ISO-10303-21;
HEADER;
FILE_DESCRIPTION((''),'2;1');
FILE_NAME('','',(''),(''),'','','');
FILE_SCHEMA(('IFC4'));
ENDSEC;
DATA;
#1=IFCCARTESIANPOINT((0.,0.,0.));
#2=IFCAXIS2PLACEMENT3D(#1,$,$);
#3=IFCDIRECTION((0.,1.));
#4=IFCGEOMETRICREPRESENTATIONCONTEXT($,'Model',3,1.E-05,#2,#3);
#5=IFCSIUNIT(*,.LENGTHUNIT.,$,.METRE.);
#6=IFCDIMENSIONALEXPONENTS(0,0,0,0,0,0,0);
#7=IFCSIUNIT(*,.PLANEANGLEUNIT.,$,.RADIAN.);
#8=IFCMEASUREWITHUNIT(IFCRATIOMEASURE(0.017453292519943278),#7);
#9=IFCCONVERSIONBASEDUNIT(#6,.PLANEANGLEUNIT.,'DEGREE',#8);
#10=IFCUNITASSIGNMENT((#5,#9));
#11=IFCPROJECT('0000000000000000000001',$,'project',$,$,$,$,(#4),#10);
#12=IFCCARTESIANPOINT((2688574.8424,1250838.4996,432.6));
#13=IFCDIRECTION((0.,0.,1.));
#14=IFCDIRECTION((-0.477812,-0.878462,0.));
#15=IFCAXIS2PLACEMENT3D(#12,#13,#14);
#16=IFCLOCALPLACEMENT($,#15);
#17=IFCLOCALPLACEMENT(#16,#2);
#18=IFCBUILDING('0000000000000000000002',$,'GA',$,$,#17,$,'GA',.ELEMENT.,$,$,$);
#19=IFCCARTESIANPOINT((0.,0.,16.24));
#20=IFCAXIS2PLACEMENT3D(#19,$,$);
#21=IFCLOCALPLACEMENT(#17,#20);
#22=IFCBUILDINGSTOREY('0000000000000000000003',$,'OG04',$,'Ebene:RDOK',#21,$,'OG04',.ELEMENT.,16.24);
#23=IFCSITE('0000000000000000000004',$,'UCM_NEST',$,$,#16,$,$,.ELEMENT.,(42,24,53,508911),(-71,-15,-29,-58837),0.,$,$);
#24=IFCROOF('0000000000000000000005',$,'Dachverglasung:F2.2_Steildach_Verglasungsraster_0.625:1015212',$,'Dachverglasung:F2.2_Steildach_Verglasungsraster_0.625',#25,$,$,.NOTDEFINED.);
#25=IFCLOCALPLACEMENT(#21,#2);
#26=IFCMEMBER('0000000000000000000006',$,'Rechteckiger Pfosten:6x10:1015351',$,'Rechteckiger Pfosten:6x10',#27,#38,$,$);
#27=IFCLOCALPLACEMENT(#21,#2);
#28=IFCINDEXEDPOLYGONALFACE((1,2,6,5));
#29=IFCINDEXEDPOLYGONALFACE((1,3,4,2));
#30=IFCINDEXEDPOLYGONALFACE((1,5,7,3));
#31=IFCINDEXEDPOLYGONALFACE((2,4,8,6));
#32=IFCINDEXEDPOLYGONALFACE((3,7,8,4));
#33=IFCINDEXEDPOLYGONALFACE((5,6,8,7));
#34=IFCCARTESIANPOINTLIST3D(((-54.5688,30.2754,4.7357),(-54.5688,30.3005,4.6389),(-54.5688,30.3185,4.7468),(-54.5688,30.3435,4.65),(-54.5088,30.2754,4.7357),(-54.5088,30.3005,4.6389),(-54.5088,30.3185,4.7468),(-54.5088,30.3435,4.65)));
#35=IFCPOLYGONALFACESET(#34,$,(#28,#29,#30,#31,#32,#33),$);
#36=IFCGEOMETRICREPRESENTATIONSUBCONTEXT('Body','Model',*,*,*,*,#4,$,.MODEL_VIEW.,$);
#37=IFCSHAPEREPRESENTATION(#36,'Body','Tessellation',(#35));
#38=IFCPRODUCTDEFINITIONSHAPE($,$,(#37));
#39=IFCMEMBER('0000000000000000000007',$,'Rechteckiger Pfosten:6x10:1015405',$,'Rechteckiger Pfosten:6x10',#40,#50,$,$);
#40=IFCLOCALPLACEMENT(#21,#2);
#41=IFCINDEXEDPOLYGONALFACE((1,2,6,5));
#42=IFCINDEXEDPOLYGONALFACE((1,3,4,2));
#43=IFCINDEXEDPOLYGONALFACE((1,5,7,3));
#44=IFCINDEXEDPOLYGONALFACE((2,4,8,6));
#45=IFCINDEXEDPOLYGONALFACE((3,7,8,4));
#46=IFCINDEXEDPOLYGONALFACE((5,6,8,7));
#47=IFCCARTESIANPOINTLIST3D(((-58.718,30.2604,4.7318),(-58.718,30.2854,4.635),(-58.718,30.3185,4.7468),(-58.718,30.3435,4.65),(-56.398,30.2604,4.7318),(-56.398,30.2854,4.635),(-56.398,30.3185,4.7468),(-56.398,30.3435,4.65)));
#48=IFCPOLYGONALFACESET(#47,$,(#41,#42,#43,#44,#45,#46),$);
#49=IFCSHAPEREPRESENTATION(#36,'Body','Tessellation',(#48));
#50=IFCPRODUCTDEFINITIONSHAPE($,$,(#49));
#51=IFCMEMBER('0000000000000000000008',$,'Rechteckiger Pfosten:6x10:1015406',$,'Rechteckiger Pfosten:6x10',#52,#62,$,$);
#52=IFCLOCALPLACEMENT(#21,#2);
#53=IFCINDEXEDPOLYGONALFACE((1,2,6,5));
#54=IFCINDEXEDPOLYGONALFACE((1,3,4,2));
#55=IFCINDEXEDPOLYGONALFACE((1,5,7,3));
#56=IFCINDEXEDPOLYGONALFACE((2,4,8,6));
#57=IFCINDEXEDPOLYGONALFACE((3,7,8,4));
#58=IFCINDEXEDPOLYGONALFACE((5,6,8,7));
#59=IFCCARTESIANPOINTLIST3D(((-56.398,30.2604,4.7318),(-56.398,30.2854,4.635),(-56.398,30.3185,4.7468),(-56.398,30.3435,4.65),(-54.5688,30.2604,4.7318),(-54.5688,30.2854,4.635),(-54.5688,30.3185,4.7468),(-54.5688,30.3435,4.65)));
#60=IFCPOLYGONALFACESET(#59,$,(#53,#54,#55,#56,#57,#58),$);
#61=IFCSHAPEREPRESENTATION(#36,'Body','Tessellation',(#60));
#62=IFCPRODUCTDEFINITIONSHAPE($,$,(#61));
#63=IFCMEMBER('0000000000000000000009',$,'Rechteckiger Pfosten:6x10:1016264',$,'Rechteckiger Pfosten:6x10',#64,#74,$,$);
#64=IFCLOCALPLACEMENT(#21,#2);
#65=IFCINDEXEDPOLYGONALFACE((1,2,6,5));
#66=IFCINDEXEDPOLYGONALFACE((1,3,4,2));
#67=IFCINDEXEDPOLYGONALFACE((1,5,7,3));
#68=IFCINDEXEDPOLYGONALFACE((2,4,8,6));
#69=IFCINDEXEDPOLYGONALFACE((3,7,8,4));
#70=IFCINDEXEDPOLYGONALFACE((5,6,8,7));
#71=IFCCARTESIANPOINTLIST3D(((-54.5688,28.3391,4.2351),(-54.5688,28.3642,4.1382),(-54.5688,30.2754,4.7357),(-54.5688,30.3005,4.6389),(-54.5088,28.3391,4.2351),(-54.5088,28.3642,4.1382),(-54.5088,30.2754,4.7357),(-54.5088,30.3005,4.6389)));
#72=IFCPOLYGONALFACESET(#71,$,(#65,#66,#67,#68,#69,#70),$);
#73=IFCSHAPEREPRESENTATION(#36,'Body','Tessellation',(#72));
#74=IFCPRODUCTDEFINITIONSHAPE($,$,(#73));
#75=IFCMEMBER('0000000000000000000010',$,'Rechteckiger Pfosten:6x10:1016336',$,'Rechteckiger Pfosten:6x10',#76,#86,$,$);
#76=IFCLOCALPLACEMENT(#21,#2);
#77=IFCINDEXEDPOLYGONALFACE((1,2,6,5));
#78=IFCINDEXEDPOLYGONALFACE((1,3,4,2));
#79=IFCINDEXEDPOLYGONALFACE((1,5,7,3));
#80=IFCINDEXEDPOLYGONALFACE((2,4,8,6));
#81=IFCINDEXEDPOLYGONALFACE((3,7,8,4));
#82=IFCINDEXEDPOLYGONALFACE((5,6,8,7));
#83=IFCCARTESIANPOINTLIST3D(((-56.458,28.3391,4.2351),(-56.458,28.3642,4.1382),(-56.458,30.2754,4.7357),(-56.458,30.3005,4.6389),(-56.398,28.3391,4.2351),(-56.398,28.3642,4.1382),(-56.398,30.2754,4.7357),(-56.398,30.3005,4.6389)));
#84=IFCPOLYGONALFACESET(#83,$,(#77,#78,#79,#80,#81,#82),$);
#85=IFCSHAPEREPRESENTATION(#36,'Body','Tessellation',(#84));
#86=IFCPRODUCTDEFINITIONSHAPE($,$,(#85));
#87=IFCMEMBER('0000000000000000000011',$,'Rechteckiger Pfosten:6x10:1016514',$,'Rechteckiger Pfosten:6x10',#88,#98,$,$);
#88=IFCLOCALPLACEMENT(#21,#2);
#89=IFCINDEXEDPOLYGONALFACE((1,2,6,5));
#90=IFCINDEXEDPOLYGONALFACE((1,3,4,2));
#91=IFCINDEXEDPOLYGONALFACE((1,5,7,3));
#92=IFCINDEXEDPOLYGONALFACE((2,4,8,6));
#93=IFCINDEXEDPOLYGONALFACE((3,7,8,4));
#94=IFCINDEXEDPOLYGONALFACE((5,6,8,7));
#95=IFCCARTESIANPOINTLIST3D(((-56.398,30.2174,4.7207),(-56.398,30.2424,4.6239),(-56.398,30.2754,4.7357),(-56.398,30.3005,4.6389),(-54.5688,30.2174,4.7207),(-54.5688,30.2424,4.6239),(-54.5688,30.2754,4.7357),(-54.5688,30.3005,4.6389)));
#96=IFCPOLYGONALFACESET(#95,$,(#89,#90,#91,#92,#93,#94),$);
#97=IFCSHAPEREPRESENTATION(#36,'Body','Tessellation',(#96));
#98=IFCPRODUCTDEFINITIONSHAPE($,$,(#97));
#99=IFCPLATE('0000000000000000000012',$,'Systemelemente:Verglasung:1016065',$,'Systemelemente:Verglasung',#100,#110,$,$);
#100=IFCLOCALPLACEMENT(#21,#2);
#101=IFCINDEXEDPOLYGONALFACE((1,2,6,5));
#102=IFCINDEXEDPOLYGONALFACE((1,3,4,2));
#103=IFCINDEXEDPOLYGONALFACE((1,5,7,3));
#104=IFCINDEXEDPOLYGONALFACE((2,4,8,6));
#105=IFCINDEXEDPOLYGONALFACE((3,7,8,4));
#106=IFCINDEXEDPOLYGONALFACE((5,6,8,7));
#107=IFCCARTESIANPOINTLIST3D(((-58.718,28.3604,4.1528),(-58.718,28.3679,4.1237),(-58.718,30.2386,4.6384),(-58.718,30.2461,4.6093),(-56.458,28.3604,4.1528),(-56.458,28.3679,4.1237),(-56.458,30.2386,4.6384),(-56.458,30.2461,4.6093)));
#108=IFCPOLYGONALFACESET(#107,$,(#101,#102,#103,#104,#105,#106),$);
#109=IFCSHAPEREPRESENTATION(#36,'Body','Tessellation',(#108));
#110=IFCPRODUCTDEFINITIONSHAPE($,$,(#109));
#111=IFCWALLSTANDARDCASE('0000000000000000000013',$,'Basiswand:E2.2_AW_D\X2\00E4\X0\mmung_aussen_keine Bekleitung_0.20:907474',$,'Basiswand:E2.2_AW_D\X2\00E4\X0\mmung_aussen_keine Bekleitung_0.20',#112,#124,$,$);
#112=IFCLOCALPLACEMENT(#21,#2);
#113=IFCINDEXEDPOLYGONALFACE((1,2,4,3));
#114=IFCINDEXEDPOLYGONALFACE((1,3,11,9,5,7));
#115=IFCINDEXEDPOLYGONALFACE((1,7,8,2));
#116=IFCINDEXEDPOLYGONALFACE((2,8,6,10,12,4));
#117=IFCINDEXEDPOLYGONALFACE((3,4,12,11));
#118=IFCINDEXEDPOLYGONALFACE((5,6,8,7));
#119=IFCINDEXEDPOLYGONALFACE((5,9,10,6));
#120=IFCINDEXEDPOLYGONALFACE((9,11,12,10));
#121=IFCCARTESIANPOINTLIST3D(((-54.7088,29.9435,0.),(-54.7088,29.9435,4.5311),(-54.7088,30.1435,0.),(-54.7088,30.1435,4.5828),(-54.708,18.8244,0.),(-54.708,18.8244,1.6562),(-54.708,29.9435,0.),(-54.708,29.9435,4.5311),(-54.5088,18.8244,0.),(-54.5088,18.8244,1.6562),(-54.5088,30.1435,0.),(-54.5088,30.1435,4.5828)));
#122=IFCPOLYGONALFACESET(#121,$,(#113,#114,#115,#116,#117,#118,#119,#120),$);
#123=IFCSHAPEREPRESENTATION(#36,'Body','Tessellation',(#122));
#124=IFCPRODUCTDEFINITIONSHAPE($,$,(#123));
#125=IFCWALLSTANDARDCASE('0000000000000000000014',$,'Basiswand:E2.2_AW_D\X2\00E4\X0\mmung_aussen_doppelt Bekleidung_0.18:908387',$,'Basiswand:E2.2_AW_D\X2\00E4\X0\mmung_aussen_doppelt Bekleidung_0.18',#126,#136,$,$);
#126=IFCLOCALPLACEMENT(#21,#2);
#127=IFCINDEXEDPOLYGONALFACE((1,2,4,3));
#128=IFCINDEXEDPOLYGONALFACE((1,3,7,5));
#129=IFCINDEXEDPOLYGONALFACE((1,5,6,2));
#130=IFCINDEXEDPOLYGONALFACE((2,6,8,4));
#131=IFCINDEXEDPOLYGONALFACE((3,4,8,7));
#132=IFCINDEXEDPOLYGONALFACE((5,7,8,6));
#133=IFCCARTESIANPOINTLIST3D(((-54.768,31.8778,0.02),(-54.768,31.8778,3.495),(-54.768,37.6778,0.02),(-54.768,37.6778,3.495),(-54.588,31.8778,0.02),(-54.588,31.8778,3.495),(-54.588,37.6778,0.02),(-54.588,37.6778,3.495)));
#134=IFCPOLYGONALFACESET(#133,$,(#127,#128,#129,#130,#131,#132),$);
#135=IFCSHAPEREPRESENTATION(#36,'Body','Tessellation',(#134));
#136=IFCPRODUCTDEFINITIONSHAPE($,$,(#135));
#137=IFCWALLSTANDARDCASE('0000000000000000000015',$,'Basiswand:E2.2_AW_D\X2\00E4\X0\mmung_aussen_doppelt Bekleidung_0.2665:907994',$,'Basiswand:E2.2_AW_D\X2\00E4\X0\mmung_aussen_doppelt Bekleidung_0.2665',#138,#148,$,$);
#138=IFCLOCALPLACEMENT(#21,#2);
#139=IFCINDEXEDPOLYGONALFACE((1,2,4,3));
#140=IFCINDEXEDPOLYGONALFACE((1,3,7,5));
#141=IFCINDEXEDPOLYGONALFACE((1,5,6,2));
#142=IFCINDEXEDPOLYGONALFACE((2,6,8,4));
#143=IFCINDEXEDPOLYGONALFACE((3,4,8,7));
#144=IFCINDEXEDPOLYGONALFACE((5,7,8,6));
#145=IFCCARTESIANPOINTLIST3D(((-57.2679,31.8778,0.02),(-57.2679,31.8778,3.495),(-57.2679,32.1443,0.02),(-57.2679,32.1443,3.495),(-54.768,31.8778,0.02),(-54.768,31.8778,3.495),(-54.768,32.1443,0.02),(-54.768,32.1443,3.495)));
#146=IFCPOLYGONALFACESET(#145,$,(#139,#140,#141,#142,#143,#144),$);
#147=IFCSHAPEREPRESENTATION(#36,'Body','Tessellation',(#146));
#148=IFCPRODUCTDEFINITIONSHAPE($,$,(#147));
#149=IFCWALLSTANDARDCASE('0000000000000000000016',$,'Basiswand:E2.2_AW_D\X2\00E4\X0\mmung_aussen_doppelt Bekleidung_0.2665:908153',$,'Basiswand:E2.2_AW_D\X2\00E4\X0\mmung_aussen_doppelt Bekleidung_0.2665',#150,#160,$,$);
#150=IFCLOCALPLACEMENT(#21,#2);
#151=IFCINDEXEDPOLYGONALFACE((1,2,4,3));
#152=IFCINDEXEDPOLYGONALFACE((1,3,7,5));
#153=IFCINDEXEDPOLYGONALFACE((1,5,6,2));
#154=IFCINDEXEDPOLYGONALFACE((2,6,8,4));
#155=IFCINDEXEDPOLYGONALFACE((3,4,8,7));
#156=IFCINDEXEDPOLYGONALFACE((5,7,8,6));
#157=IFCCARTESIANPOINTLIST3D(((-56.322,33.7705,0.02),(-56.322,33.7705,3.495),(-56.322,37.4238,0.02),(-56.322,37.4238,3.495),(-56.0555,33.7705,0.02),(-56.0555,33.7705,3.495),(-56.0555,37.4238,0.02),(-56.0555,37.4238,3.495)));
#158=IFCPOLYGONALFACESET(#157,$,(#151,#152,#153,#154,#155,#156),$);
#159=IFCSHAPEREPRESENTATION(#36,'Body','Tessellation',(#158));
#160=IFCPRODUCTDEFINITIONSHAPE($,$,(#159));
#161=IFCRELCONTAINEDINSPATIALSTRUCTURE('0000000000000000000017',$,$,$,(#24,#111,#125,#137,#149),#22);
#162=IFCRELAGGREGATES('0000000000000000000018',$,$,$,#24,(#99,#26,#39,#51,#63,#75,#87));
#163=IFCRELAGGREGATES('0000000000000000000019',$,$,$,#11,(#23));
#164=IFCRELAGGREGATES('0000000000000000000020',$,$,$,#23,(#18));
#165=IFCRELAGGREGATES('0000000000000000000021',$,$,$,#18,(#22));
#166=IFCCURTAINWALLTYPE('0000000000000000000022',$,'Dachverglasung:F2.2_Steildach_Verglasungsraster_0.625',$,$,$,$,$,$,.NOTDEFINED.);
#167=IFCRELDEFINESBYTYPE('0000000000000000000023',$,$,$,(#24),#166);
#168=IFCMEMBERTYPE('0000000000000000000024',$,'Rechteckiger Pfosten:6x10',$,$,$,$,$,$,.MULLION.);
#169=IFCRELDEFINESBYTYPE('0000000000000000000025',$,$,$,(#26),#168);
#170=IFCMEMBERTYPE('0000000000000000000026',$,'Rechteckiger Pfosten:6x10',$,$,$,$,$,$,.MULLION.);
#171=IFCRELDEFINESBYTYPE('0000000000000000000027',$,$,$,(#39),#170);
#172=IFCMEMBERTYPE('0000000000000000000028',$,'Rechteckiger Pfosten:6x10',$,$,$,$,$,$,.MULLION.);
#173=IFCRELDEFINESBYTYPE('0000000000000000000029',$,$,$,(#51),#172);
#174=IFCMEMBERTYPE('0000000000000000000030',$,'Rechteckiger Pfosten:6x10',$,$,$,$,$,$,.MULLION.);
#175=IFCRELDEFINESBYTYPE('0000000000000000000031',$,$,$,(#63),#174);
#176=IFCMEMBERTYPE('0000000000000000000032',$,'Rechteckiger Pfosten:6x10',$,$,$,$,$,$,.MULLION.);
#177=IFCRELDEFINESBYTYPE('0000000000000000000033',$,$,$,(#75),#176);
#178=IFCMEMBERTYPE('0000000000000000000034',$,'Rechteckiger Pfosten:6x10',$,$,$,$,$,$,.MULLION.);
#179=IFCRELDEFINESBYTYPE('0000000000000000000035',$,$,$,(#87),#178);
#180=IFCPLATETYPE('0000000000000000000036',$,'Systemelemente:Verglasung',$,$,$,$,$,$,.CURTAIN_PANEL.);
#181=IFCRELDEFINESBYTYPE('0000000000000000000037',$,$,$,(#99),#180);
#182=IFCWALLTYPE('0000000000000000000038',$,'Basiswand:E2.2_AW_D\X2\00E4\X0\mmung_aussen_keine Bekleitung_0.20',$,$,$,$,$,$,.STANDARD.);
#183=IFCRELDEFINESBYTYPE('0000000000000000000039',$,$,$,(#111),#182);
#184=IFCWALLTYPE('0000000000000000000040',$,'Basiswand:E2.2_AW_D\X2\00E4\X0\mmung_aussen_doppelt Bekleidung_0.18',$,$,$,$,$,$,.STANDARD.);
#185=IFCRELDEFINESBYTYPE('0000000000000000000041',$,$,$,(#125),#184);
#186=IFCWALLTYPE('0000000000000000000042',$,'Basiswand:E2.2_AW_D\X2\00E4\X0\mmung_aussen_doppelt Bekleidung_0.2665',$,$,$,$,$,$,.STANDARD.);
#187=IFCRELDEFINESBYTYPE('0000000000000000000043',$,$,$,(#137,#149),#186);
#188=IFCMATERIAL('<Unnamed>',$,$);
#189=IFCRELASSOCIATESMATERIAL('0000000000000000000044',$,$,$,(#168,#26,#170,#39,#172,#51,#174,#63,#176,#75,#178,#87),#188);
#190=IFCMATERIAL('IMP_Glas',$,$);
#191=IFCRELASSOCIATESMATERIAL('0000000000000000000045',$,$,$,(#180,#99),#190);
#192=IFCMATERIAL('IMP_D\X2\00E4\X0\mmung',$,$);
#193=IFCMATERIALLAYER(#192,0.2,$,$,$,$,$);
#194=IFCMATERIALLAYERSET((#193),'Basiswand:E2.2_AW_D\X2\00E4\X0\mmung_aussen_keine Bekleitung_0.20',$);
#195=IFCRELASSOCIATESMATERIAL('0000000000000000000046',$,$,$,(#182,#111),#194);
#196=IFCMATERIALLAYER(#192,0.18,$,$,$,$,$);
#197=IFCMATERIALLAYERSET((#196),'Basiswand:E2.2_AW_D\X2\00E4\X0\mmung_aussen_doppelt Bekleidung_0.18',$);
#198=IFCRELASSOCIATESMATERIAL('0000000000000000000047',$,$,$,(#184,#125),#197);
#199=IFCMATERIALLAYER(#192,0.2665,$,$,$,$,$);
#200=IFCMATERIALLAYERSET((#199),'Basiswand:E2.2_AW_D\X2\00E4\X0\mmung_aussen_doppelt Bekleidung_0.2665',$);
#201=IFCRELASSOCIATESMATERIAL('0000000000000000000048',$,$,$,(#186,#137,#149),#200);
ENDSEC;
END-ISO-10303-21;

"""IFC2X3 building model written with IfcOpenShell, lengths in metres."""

from ifc_helpers import new_model, entity, si_unit, converted_unit, direction, frame, frame_2d, origin, origin_2d_with_axis, place, context, subcontext, project, spatial, polyline, rectangle, extrude, clip, halfspace, bounded_halfspace, source, transform, mapped, material, layer, layer_set, layer_usage, type_object, type_shapes, element, aggregate, save


model = new_model("IFC2X3")

# Units and contexts
model_context = context("Model", 3, precision=1e-05, world=origin(), true_north=direction((0.0, 1.0)))
body_context = subcontext(model_context, "Body", "Model", "MODEL_VIEW")
ifc_project = project(units=[si_unit("LENGTHUNIT", "METRE"), converted_unit("PLANEANGLEUNIT", "DEGREE", entity("IfcRatioMeasure", 0.017453292519943278), si_unit("PLANEANGLEUNIT", "RADIAN"), dimensions=[0, 0, 0, 0, 0, 0, 0])], contexts=[model_context])

# Site, building, storey
site_placement = place(None, frame((2688574.8424, 1250838.4996, 432.6), z_axis=(0.0, 0.0, 1.0), x_axis=(-0.477812, -0.878462, 0.0)))
site = spatial("IfcSite", under=ifc_project, at=site_placement, Name="UCM_NEST", CompositionType="ELEMENT", RefLatitude=(42, 24, 53, 508911), RefLongitude=(-71, -15, -29, -58837), RefElevation=0.0)
building_placement = place(site_placement, origin())
building = spatial("IfcBuilding", under=site, at=building_placement, Name="GA", LongName="GA", CompositionType="ELEMENT")
storey_placement = place(building_placement, frame((0.0, 0.0, 16.24)))
storey = spatial("IfcBuildingStorey", under=building, at=storey_placement, Name="OG04", ObjectType="Ebene:RDOK", LongName="OG04", CompositionType="ELEMENT", Elevation=16.24)

# Roof, members, plate
curtain_wall_type = type_object("IfcCurtainWallType", Name="Dachverglasung:F2.2_Steildach_Verglasungsraster_0.625", PredefinedType="NOTDEFINED")
roof_placement = place(storey_placement, frame((0.0, 0.0, -16.24)))
roof = element("IfcRoof", 1, at=roof_placement, inside=storey, type_object=curtain_wall_type, Name="Dachverglasung:F2.2_Steildach_Verglasungsraster_0.625:1015212", ObjectType="Dachverglasung:F2.2_Steildach_Verglasungsraster_0.625", ShapeType="NOTDEFINED")
ifc_material_1 = material(Name="<Unnamed>")
member_type_1 = type_object("IfcMemberType", Name="Rechteckiger Pfosten:6x10", PredefinedType="MULLION", material=ifc_material_1)
shared_shape_1 = source(origin(), body_context, "Body", "SweptSolid", [
    extrude(rectangle(XDim=0.1, YDim=0.06, at=origin_2d_with_axis()), frame((-0.03, -0.05, -0.0444), z_axis=(0.0, 0.0, 1.0), x_axis=(0.0, -1.0, 0.0)), (0.0, 0.0, 1.0), 0.0444),
])
type_shapes(member_type_1, [shared_shape_1])
member_1_placement = place(roof_placement, frame((-54.5088, 30.3435, 20.89), z_axis=(0.0, 0.968163, 0.250322), x_axis=(1.0, 0.0, 0.0)))
member_1 = element("IfcMember", 2, at=member_1_placement, type_object=member_type_1, material=ifc_material_1, Name="Rechteckiger Pfosten:6x10:1015351", ObjectType="Rechteckiger Pfosten:6x10", context=body_context, shape_type="MappedRepresentation", body=[
    mapped(shared_shape_1, transform((0.0, 0.0, 0.0), scale=1.0)),
])
member_type_2 = type_object("IfcMemberType", Name="Rechteckiger Pfosten:6x10", PredefinedType="MULLION", material=ifc_material_1)
shared_shape_2 = source(origin(), body_context, "Body", "SweptSolid", [
    extrude(rectangle(XDim=0.1, YDim=0.06, at=origin_2d_with_axis()), frame((-0.03, -0.05, -2.32), z_axis=(0.0, 0.0, 1.0), x_axis=(0.0, -1.0, 0.0)), (0.0, 0.0, 1.0), 2.32),
])
type_shapes(member_type_2, [shared_shape_2])
member_2_placement = place(roof_placement, frame((-58.718, 30.3435, 20.89), z_axis=(-1.0, 0.0, 0.0), x_axis=(0.0, 0.968163, 0.250322)))
member_2 = element("IfcMember", 3, at=member_2_placement, type_object=member_type_2, material=ifc_material_1, Name="Rechteckiger Pfosten:6x10:1015405", ObjectType="Rechteckiger Pfosten:6x10", context=body_context, shape_type="MappedRepresentation", body=[
    mapped(shared_shape_2, transform((0.0, 0.0, 0.0), scale=1.0)),
])
member_type_3 = type_object("IfcMemberType", Name="Rechteckiger Pfosten:6x10", PredefinedType="MULLION", material=ifc_material_1)
shared_shape_3 = source(origin(), body_context, "Body", "SweptSolid", [
    extrude(rectangle(XDim=0.1, YDim=0.06, at=origin_2d_with_axis()), frame((-0.03, -0.05, -1.8292), z_axis=(0.0, 0.0, 1.0), x_axis=(0.0, -1.0, 0.0)), (0.0, 0.0, 1.0), 1.8292),
])
type_shapes(member_type_3, [shared_shape_3])
member_3_placement = place(roof_placement, frame((-56.398, 30.3435, 20.89), z_axis=(-1.0, 0.0, 0.0), x_axis=(0.0, 0.968163, 0.250322)))
member_3 = element("IfcMember", 4, at=member_3_placement, type_object=member_type_3, material=ifc_material_1, Name="Rechteckiger Pfosten:6x10:1015406", ObjectType="Rechteckiger Pfosten:6x10", context=body_context, shape_type="MappedRepresentation", body=[
    mapped(shared_shape_3, transform((0.0, 0.0, 0.0), scale=1.0)),
])
member_type_4 = type_object("IfcMemberType", Name="Rechteckiger Pfosten:6x10", PredefinedType="MULLION", material=ifc_material_1)
shared_shape_4 = source(origin(), body_context, "Body", "SweptSolid", [
    extrude(rectangle(XDim=0.1, YDim=0.06, at=origin_2d_with_axis()), frame((-0.03, -0.05, -2.0), z_axis=(0.0, 0.0, 1.0), x_axis=(0.0, -1.0, 0.0)), (0.0, 0.0, 1.0), 2.0),
])
type_shapes(member_type_4, [shared_shape_4])
member_4_placement = place(roof_placement, frame((-54.5088, 30.3005, 20.8789), z_axis=(0.0, 0.968163, 0.250322), x_axis=(1.0, 0.0, 0.0)))
member_4 = element("IfcMember", 5, at=member_4_placement, type_object=member_type_4, material=ifc_material_1, Name="Rechteckiger Pfosten:6x10:1016264", ObjectType="Rechteckiger Pfosten:6x10", context=body_context, shape_type="MappedRepresentation", body=[
    mapped(shared_shape_4, transform((0.0, 0.0, 0.0), scale=1.0)),
])
member_type_5 = type_object("IfcMemberType", Name="Rechteckiger Pfosten:6x10", PredefinedType="MULLION", material=ifc_material_1)
shared_shape_5 = source(origin(), body_context, "Body", "SweptSolid", [
    extrude(rectangle(XDim=0.1, YDim=0.06, at=origin_2d_with_axis()), frame((-0.03, -0.05, -2.0), z_axis=(0.0, 0.0, 1.0), x_axis=(0.0, -1.0, 0.0)), (0.0, 0.0, 1.0), 2.0),
])
type_shapes(member_type_5, [shared_shape_5])
member_5_placement = place(roof_placement, frame((-56.398, 30.3005, 20.8789), z_axis=(0.0, 0.968163, 0.250322), x_axis=(1.0, 0.0, 0.0)))
member_5 = element("IfcMember", 6, at=member_5_placement, type_object=member_type_5, material=ifc_material_1, Name="Rechteckiger Pfosten:6x10:1016336", ObjectType="Rechteckiger Pfosten:6x10", context=body_context, shape_type="MappedRepresentation", body=[
    mapped(shared_shape_5, transform((0.0, 0.0, 0.0), scale=1.0)),
])
member_type_6 = type_object("IfcMemberType", Name="Rechteckiger Pfosten:6x10", PredefinedType="MULLION", material=ifc_material_1)
shared_shape_6 = source(origin(), body_context, "Body", "SweptSolid", [
    extrude(rectangle(XDim=0.1, YDim=0.06, at=origin_2d_with_axis()), frame((-0.03, -0.05, -1.8292), z_axis=(0.0, 0.0, 1.0), x_axis=(0.0, -1.0, 0.0)), (0.0, 0.0, 1.0), 1.8292),
])
type_shapes(member_type_6, [shared_shape_6])
member_6_placement = place(roof_placement, frame((-56.398, 30.3005, 20.8789), z_axis=(-1.0, 0.0, 0.0), x_axis=(0.0, 0.968163, 0.250322)))
member_6 = element("IfcMember", 7, at=member_6_placement, type_object=member_type_6, material=ifc_material_1, Name="Rechteckiger Pfosten:6x10:1016514", ObjectType="Rechteckiger Pfosten:6x10", context=body_context, shape_type="MappedRepresentation", body=[
    mapped(shared_shape_6, transform((0.0, 0.0, 0.0), scale=1.0)),
])
ifc_material_2 = material(Name="IMP_Glas")
plate_type = type_object("IfcPlateType", Name="Systemelemente:Verglasung", PredefinedType="CURTAIN_PANEL", material=ifc_material_2)
shared_shape_7 = source(origin(), body_context, "Body", "SweptSolid", [
    extrude(rectangle(XDim=0.03, YDim=2.26, at=origin_2d_with_axis()), frame((0.0, 0.0, 0.0), z_axis=(0.0, 0.0, 1.0), x_axis=(0.0, 1.0, 0.0)), (0.0, 0.0, 1.0), 1.94),
])
type_shapes(plate_type, [shared_shape_7])
plate_placement = place(roof_placement, frame((-57.588, 28.3642, 20.3782), z_axis=(0.0, 0.968163, 0.250322), x_axis=(1.0, 0.0, 0.0)))
plate = element("IfcPlate", 8, at=plate_placement, type_object=plate_type, material=ifc_material_2, Name="Systemelemente:Verglasung:1016065", ObjectType="Systemelemente:Verglasung", context=body_context, shape_type="MappedRepresentation", body=[
    mapped(shared_shape_7, transform((0.0, 0.0, 0.0), scale=1.0)),
])
aggregate(roof, [plate, member_1, member_2, member_3, member_4, member_5, member_6])

# Walls
ifc_material_3 = material(Name="IMP_Dämmung")
ifc_layer_1 = layer(ifc_material_3, 0.2)
ifc_layer_set_1 = layer_set([ifc_layer_1], Name="Basiswand:E2.2_AW_Dämmung_aussen_keine Bekleitung_0.20")
ifc_layer_usage_1 = layer_usage(ifc_layer_set_1, "AXIS2", "NEGATIVE", 0.1)
wall_type_1 = type_object("IfcWallType", Name="Basiswand:E2.2_AW_Dämmung_aussen_keine Bekleitung_0.20", PredefinedType="STANDARD", material=ifc_layer_set_1)
wall_1_placement = place(storey_placement, frame((-54.6088, 30.1435, 0.0), z_axis=(0.0, 0.0, 1.0), x_axis=(0.0, -1.0, 0.0)))
element("IfcWallStandardCase", 9, at=wall_1_placement, inside=storey, type_object=wall_type_1, material=ifc_layer_usage_1, Name="Basiswand:E2.2_AW_Dämmung_aussen_keine Bekleitung_0.20:907474", ObjectType="Basiswand:E2.2_AW_Dämmung_aussen_keine Bekleitung_0.20", context=body_context, shape_type="Clipping", body=[
    clip(clip(clip(extrude(rectangle(XDim=11.319, YDim=0.2, at=frame_2d((5.6595, 0.0), x_axis=(-1.0, 0.0))), origin(), (0.0, 0.0, 1.0), 4.5828), bounded_halfspace(frame((0.2, -0.0992, 4.5311), z_axis=(0.0, 1.0, 0.0), x_axis=(-1.0, 0.0, 0.0)), True, frame((0.2, -0.0992, 4.5311), z_axis=(0.0, 1.0, 0.0), x_axis=(-1.0, 0.0, 0.0)), polyline([(0.0, 0.0), (-11.119, -2.8749), (-11.119, -4.5311), (0.0, -4.5311), (0.0, 0.0)]))), bounded_halfspace(frame((0.2, -0.0992, 0.0), z_axis=(1.0, 0.0, 0.0), x_axis=(0.0, 1.0, 0.0)), False, frame((0.2, -0.0992, 0.0), z_axis=(1.0, 0.0, 0.0), x_axis=(0.0, 1.0, 0.0)), polyline([(0.0, 0.0), (0.0, 4.5311), (-0.0008, 4.5311), (-0.0008, 0.0), (0.0, 0.0)]))), halfspace(frame((11.319, 0.1, 1.6562), z_axis=(0.250322, 0.0, 0.968163), x_axis=(0.0, 1.0, 0.0)), False)),
])
ifc_layer_2 = layer(ifc_material_3, 0.18)
ifc_layer_set_2 = layer_set([ifc_layer_2], Name="Basiswand:E2.2_AW_Dämmung_aussen_doppelt Bekleidung_0.18")
ifc_layer_usage_2 = layer_usage(ifc_layer_set_2, "AXIS2", "NEGATIVE", 0.09)
wall_type_2 = type_object("IfcWallType", Name="Basiswand:E2.2_AW_Dämmung_aussen_doppelt Bekleidung_0.18", PredefinedType="STANDARD", material=ifc_layer_set_2)
wall_2_placement = place(storey_placement, frame((-54.678, 31.8778, 0.02), z_axis=(0.0, 0.0, 1.0), x_axis=(0.0, 1.0, 0.0)))
element("IfcWallStandardCase", 10, at=wall_2_placement, inside=storey, type_object=wall_type_2, material=ifc_layer_usage_2, Name="Basiswand:E2.2_AW_Dämmung_aussen_doppelt Bekleidung_0.18:908387", ObjectType="Basiswand:E2.2_AW_Dämmung_aussen_doppelt Bekleidung_0.18", context=body_context, shape_type="SweptSolid", body=[
    extrude(rectangle(XDim=5.8, YDim=0.18, at=frame_2d((2.9, 0.0), x_axis=(-1.0, 0.0))), origin(), (0.0, 0.0, 1.0), 3.475),
])
ifc_layer_3 = layer(ifc_material_3, 0.2665)
ifc_layer_set_3 = layer_set([ifc_layer_3], Name="Basiswand:E2.2_AW_Dämmung_aussen_doppelt Bekleidung_0.2665")
ifc_layer_usage_3 = layer_usage(ifc_layer_set_3, "AXIS2", "NEGATIVE", 0.1333)
wall_type_3 = type_object("IfcWallType", Name="Basiswand:E2.2_AW_Dämmung_aussen_doppelt Bekleidung_0.2665", PredefinedType="STANDARD", material=ifc_layer_set_3)
wall_3_placement = place(storey_placement, frame((-57.2679, 32.011, 0.02)))
element("IfcWallStandardCase", 11, at=wall_3_placement, inside=storey, type_object=wall_type_3, material=ifc_layer_usage_3, Name="Basiswand:E2.2_AW_Dämmung_aussen_doppelt Bekleidung_0.2665:907994", ObjectType="Basiswand:E2.2_AW_Dämmung_aussen_doppelt Bekleidung_0.2665", context=body_context, shape_type="SweptSolid", body=[
    extrude(rectangle(XDim=2.4999, YDim=0.2665, at=frame_2d((1.25, 0.0), x_axis=(-1.0, 0.0))), origin(), (0.0, 0.0, 1.0), 3.475),
])

# Wall
wall_4_placement = place(storey_placement, frame((-56.1887, 33.7705, 0.02), z_axis=(0.0, 0.0, 1.0), x_axis=(0.0, 1.0, 0.0)))
element("IfcWallStandardCase", 12, at=wall_4_placement, inside=storey, type_object=wall_type_3, material=ifc_layer_usage_3, Name="Basiswand:E2.2_AW_Dämmung_aussen_doppelt Bekleidung_0.2665:908153", ObjectType="Basiswand:E2.2_AW_Dämmung_aussen_doppelt Bekleidung_0.2665", context=body_context, shape_type="SweptSolid", body=[
    extrude(rectangle(XDim=3.6533, YDim=0.2665, at=frame_2d((1.8266, 0.0), x_axis=(-1.0, 0.0))), origin(), (0.0, 0.0, 1.0), 3.475),
])

save(model, "model.ifc")
